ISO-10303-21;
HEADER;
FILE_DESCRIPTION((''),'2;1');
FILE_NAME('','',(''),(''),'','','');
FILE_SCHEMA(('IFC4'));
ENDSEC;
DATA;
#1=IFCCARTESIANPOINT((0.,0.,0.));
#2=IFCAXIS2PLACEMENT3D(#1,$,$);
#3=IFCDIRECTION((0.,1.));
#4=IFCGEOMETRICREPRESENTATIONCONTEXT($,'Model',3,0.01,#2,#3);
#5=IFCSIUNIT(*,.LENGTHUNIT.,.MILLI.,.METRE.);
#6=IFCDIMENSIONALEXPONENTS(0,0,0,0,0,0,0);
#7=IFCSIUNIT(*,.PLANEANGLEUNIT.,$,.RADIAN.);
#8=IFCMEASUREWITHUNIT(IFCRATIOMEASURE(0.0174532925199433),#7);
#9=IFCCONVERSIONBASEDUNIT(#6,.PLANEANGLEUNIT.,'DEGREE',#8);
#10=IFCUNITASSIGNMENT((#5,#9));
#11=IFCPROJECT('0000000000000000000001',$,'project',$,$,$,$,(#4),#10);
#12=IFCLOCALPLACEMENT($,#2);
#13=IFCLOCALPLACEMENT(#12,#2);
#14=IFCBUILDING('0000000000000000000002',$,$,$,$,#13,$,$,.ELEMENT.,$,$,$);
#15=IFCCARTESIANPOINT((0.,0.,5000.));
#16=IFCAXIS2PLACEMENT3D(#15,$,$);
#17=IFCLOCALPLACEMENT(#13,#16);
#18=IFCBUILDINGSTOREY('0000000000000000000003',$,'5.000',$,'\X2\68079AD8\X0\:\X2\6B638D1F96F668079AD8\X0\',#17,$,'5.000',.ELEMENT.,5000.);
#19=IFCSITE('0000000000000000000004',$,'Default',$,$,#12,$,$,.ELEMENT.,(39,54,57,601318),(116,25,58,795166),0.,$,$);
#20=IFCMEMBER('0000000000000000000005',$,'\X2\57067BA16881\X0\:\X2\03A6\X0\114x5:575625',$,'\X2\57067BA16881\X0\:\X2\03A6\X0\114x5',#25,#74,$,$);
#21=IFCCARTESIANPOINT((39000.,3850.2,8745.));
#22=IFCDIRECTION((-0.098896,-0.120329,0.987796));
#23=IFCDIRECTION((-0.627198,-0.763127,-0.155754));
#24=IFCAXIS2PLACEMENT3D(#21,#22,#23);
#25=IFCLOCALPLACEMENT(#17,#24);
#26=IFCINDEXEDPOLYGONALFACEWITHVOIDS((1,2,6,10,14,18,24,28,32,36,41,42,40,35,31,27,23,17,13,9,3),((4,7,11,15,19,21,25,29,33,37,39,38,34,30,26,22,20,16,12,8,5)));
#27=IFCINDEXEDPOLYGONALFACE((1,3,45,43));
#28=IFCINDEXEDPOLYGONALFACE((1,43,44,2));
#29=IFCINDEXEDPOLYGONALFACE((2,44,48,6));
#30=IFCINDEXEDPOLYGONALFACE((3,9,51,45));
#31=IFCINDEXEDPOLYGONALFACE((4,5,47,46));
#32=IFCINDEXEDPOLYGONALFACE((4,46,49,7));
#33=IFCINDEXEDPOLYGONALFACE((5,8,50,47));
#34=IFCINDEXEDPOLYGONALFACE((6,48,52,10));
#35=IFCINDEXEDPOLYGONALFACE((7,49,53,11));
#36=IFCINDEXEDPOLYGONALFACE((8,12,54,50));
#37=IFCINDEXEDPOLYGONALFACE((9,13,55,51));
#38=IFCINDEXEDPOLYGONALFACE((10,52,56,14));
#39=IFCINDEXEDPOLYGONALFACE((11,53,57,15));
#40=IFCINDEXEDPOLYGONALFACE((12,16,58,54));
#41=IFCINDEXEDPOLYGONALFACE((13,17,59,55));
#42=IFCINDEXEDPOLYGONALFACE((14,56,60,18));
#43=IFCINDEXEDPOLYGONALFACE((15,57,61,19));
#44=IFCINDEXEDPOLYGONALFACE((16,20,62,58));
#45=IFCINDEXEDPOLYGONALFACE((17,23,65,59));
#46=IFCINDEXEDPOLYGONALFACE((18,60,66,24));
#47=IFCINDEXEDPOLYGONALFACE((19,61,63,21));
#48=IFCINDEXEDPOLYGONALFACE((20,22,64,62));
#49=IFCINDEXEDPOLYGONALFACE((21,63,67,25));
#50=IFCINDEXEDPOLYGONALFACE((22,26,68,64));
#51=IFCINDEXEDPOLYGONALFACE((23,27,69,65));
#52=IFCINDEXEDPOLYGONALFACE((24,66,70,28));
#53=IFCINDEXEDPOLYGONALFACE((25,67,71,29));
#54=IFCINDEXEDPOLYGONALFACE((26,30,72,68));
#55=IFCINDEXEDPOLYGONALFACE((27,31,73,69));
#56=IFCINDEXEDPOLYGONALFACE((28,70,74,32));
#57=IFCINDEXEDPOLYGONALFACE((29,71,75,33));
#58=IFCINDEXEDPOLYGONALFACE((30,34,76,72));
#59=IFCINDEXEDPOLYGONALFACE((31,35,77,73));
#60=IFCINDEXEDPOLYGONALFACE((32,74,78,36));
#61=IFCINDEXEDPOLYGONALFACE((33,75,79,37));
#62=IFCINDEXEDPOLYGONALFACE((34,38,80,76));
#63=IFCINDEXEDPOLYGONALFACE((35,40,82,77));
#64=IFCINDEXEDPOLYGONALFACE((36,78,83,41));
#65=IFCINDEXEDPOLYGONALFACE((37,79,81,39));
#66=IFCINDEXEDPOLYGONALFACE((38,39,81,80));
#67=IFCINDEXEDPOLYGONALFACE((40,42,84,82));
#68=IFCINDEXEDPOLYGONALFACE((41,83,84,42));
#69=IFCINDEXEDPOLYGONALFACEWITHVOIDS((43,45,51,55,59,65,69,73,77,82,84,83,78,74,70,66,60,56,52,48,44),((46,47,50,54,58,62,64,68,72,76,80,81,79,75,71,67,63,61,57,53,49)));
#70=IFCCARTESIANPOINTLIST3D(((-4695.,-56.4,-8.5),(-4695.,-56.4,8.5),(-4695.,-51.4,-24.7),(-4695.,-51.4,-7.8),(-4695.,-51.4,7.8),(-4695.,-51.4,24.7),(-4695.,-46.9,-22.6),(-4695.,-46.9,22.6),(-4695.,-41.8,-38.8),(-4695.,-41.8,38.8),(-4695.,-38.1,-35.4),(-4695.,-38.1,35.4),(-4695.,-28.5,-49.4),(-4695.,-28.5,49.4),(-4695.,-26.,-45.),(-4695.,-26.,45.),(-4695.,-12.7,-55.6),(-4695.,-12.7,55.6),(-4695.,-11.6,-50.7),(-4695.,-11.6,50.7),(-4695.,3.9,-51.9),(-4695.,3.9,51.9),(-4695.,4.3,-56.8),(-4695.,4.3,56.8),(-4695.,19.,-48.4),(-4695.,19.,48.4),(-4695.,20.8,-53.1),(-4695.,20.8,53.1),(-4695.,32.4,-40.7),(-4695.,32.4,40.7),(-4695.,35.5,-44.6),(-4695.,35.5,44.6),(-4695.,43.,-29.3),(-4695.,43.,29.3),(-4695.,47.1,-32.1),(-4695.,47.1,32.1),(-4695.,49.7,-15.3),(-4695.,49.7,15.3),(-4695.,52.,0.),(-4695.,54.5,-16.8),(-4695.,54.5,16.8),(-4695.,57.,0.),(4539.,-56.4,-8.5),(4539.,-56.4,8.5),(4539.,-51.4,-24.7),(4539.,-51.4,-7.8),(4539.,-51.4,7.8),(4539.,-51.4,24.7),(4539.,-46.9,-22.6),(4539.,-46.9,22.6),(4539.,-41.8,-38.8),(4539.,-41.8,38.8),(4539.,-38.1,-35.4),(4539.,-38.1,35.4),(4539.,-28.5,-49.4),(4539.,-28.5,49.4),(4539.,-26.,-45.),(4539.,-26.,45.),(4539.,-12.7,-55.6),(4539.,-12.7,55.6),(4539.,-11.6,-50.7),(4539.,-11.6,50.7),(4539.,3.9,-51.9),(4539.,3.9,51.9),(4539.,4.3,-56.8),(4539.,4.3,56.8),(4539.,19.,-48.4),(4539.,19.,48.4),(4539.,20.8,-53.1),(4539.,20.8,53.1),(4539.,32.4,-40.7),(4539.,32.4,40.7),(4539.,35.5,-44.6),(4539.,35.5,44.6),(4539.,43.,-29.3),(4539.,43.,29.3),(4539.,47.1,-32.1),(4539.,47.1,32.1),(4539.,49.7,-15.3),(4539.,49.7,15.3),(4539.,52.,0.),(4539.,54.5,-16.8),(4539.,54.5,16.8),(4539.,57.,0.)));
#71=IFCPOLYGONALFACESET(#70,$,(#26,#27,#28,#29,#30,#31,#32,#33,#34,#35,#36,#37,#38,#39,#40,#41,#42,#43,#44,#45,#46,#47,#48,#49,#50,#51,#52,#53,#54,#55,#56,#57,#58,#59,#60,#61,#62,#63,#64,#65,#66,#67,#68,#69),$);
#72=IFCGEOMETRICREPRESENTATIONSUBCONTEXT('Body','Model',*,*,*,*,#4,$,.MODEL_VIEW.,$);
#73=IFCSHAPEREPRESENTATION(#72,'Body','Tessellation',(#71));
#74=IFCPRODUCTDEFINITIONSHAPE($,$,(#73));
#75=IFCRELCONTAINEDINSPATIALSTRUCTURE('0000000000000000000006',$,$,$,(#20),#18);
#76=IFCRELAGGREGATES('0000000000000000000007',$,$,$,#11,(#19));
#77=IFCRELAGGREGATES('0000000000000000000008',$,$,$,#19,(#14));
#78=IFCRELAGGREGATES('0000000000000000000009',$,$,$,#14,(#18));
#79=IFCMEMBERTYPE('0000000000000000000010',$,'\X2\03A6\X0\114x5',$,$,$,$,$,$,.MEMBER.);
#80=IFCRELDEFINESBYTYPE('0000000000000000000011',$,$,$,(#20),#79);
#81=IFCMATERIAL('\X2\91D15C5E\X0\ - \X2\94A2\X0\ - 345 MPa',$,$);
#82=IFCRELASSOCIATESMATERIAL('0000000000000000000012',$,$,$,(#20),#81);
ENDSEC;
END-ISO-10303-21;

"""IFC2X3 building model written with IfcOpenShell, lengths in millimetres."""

from ifc_helpers import new_model, entity, si_unit, converted_unit, direction, frame, frame_2d, origin, place, context, subcontext, project, spatial, hollow_circle, extrude, source, transform, mapped, material, type_object, type_shapes, element, save


model = new_model("IFC2X3")

# Units and contexts
model_context = context("Model", 3, precision=0.01, world=origin(), true_north=direction((0.0, 1.0)))
body_context = subcontext(model_context, "Body", "Model", "MODEL_VIEW")
ifc_project = project(units=[si_unit("LENGTHUNIT", "METRE", prefix="MILLI"), converted_unit("PLANEANGLEUNIT", "DEGREE", entity("IfcRatioMeasure", 0.0174532925199433), si_unit("PLANEANGLEUNIT", "RADIAN"), dimensions=[0, 0, 0, 0, 0, 0, 0])], contexts=[model_context])

# Site, building, storey
site_placement = place(None, origin())
site = spatial("IfcSite", under=ifc_project, at=site_placement, Name="Default", CompositionType="ELEMENT", RefLatitude=(39, 54, 57, 601318), RefLongitude=(116, 25, 58, 795166), RefElevation=0.0)
building_placement = place(site_placement, origin())
building = spatial("IfcBuilding", under=site, at=building_placement, CompositionType="ELEMENT")
storey_placement = place(building_placement, frame((0.0, 0.0, 5000.0)))
storey = spatial("IfcBuildingStorey", under=building, at=storey_placement, Name="5.000", ObjectType="标高:正负零标高", LongName="5.000", CompositionType="ELEMENT", Elevation=5000.0)

# Member
ifc_material_1 = material(Name="金属 - 钢 - 345 MPa")
member_type_1 = type_object("IfcMemberType", Name="Φ114x5", PredefinedType="MEMBER")
shared_shape_1 = source(origin(), body_context, "Body", "SweptSolid", [
    extrude(hollow_circle(Radius=57.0, WallThickness=5.0, at=frame_2d((0.0, 0.0), x_axis=(1.0, 0.0))), frame((-4695.0, 0.0, 0.0), z_axis=(1.0, 0.0, 0.0), x_axis=(0.0, 1.0, 0.0)), (0.0, 0.0, 1.0), 9234.0),
])
type_shapes(member_type_1, [shared_shape_1])
for number, where, z_axis, x_axis, name in (
    (1, (39000.0, 3850.2, 8745.0), (-0.098896, -0.120329, 0.987796), (-0.627198, -0.763127, -0.155754), "圆管梁:Φ114x5:575625"),
):
    element("IfcMember", number, at=place(storey_placement, frame(where, z_axis=z_axis, x_axis=x_axis)), inside=storey, type_object=member_type_1, material=ifc_material_1, Name=name, ObjectType="圆管梁:Φ114x5", context=body_context, shape_type="MappedRepresentation", body=[
        mapped(shared_shape_1, transform((0.0, 0.0, 0.0), scale=1.0)),
    ])

save(model, "model.ifc")
